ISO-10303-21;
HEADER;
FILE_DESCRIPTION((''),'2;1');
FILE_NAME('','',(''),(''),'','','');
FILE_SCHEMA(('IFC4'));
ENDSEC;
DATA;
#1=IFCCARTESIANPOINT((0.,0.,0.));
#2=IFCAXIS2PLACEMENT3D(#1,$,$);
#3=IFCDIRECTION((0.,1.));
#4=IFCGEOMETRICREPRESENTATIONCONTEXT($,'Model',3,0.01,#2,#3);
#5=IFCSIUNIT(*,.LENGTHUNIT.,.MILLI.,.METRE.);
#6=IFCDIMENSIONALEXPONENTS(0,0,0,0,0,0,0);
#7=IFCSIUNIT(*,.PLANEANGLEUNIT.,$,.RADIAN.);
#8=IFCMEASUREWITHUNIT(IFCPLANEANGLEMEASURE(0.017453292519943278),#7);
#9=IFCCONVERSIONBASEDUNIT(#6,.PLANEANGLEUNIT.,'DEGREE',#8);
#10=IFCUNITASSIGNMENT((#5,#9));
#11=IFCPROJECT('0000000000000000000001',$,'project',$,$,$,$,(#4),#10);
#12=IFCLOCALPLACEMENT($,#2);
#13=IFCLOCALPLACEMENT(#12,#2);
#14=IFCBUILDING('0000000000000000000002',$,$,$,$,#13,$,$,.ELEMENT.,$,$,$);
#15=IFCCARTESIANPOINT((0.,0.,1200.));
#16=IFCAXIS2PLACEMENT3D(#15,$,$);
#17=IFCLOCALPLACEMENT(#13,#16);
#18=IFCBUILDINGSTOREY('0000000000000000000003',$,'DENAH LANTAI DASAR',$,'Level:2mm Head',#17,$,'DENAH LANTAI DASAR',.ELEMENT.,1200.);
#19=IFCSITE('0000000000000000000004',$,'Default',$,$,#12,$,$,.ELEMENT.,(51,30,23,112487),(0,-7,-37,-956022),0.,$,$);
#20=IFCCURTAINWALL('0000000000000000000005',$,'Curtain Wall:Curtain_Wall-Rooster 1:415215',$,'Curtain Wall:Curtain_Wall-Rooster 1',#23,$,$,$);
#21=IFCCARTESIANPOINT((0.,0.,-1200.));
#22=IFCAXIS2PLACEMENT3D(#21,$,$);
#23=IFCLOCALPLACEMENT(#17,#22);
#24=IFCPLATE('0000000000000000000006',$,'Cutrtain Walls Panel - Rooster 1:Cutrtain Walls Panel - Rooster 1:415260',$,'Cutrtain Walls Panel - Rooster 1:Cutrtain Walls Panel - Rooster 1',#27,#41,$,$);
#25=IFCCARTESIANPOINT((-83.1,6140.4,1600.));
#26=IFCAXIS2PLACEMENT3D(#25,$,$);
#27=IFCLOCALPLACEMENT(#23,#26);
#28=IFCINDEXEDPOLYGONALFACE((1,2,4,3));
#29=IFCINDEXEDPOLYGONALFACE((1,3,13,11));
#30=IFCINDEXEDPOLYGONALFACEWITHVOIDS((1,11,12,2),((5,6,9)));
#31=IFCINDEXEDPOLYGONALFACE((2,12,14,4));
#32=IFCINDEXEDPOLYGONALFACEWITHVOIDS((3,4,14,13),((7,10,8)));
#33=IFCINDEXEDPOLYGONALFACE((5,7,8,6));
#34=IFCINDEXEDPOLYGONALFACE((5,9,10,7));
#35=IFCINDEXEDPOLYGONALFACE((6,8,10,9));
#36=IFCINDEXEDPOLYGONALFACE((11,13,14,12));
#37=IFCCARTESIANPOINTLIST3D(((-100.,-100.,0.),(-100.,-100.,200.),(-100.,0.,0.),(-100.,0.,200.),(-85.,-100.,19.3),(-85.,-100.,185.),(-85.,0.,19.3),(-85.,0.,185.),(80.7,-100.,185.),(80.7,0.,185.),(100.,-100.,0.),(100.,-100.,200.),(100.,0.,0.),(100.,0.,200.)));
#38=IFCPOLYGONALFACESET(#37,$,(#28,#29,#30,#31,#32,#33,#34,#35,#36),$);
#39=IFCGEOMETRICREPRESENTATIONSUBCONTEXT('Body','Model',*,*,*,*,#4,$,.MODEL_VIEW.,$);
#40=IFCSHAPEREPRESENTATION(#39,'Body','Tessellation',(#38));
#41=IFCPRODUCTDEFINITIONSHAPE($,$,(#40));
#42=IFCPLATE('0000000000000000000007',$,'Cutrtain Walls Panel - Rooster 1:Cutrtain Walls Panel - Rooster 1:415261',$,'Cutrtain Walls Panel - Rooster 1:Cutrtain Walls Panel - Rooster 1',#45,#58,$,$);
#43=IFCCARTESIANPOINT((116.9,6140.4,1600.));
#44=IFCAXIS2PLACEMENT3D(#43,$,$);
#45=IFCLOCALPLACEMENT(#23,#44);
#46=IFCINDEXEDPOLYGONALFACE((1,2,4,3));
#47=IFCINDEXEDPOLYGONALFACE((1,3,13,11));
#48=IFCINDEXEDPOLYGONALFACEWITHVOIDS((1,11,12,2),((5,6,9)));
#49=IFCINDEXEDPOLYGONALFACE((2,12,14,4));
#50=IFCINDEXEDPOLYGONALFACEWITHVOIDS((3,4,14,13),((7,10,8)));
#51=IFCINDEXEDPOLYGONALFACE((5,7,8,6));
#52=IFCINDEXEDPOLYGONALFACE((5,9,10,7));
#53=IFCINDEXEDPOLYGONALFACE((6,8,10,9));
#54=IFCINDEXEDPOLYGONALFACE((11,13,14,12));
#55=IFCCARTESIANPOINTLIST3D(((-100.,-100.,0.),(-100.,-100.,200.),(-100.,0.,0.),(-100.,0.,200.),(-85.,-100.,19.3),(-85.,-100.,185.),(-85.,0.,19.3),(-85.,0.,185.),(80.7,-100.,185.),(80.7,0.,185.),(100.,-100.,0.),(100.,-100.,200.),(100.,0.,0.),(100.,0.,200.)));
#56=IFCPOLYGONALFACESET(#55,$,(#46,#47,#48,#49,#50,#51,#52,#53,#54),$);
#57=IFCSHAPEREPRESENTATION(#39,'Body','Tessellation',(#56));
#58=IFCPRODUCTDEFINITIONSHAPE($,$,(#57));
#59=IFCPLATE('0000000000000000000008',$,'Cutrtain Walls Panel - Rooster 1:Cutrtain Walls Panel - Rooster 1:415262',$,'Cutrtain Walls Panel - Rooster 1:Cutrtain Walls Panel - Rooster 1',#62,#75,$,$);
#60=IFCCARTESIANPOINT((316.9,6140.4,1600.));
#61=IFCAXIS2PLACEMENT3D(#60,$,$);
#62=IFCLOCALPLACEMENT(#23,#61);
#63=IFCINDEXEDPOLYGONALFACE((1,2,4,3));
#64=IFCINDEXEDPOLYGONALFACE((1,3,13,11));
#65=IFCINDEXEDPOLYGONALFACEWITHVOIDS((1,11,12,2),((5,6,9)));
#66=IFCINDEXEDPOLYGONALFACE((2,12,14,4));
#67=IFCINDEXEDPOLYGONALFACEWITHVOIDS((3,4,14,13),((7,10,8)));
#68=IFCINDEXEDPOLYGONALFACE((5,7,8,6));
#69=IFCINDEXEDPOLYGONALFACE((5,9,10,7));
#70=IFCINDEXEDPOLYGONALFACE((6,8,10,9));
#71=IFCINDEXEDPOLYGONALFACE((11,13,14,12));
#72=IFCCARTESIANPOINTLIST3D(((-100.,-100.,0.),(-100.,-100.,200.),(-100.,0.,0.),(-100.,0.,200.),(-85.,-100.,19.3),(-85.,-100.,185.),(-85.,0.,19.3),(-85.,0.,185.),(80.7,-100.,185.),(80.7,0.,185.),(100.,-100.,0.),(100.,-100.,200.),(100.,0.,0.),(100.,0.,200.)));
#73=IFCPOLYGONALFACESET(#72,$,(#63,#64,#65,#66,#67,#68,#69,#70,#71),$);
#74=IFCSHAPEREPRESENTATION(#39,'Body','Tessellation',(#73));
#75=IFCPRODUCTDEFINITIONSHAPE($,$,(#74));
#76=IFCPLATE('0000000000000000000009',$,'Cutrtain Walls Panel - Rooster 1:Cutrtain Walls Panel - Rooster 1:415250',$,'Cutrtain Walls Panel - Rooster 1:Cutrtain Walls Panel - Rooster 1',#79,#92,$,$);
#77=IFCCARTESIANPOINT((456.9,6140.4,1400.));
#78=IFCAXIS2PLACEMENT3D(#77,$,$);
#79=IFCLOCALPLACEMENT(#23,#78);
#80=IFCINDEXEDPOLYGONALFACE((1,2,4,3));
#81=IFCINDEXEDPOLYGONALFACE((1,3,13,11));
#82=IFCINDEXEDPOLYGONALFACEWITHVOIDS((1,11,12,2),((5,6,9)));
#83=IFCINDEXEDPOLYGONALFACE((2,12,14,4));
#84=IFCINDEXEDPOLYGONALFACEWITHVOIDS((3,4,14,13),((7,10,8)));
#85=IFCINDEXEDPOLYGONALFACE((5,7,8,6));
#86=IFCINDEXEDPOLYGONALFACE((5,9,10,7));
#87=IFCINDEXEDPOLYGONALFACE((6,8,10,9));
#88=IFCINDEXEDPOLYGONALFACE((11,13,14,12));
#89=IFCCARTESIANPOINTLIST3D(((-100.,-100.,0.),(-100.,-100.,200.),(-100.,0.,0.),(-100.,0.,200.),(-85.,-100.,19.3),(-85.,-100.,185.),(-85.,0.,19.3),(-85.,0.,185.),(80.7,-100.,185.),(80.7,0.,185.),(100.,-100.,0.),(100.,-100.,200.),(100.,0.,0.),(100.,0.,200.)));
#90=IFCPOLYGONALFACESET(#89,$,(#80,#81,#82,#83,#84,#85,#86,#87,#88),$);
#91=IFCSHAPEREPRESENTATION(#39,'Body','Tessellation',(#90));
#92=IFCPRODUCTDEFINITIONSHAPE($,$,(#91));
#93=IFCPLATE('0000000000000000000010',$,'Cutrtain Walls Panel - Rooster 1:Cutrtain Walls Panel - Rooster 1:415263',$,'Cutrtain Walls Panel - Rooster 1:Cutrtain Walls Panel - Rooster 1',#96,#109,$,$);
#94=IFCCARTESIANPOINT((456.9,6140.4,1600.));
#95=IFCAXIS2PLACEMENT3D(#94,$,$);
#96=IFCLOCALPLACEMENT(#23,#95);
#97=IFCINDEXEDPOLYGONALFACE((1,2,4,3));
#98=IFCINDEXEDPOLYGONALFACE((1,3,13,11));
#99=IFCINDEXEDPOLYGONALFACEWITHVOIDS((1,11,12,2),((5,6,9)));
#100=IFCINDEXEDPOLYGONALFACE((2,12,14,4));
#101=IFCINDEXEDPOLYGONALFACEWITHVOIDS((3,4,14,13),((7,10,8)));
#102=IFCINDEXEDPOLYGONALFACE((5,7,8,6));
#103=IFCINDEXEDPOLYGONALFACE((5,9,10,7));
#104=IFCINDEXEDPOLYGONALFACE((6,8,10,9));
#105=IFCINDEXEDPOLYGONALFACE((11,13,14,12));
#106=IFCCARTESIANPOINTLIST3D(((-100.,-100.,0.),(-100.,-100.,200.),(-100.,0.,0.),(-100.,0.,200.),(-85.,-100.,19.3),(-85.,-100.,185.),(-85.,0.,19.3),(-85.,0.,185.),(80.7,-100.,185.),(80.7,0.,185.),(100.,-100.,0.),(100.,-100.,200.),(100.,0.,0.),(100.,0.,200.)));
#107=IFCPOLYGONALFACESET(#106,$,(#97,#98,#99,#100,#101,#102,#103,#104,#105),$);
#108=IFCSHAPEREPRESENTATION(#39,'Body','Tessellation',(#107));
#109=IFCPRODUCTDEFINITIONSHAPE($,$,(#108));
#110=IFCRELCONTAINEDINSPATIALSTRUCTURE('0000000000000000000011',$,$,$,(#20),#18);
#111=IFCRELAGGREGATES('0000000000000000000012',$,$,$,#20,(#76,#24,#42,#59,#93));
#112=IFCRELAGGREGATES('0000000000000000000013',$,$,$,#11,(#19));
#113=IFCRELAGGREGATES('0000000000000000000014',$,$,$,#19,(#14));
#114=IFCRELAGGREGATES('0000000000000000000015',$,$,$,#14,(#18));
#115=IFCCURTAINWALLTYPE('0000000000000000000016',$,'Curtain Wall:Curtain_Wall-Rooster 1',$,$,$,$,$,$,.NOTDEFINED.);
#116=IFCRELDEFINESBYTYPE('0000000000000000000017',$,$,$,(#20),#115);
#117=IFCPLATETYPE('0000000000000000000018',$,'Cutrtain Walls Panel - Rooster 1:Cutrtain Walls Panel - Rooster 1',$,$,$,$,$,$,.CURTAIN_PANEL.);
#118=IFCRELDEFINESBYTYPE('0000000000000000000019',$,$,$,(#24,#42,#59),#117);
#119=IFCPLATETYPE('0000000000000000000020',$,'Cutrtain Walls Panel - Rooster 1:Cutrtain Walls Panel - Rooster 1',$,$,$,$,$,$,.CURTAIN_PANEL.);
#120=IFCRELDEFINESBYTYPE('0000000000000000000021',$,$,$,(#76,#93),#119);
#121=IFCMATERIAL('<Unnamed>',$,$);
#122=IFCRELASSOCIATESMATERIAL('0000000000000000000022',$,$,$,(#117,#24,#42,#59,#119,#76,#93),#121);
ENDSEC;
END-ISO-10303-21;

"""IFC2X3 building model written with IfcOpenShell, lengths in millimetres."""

from ifc_helpers import new_model, entity, si_unit, converted_unit, direction, frame, origin, place, context, subcontext, project, spatial, polyline, outline, extrude, source, transform, mapped, material, type_object, type_shapes, element, aggregate, save


model = new_model("IFC2X3")

# Units and contexts
model_context = context("Model", 3, precision=0.01, world=origin(), true_north=direction((0.0, 1.0)))
body_context = subcontext(model_context, "Body", "Model", "MODEL_VIEW")
ifc_project = project(units=[si_unit("LENGTHUNIT", "METRE", prefix="MILLI"), converted_unit("PLANEANGLEUNIT", "DEGREE", entity("IfcPlaneAngleMeasure", 0.017453292519943278), si_unit("PLANEANGLEUNIT", "RADIAN"), dimensions=[0, 0, 0, 0, 0, 0, 0])], contexts=[model_context])

# Site, building, storey
site_placement = place(None, origin())
site = spatial("IfcSite", under=ifc_project, at=site_placement, Name="Default", CompositionType="ELEMENT", RefLatitude=(51, 30, 23, 112487), RefLongitude=(0, -7, -37, -956022), RefElevation=0.0)
building_placement = place(site_placement, origin())
building = spatial("IfcBuilding", under=site, at=building_placement, CompositionType="ELEMENT")
storey_placement = place(building_placement, frame((0.0, 0.0, 1200.0)))
storey = spatial("IfcBuildingStorey", under=building, at=storey_placement, Name="DENAH LANTAI DASAR", ObjectType="Level:2mm Head", LongName="DENAH LANTAI DASAR", CompositionType="ELEMENT", Elevation=1200.0)

# Curtain wall, plates
curtain_wall_type = type_object("IfcCurtainWallType", Name="Curtain Wall:Curtain_Wall-Rooster 1", PredefinedType="NOTDEFINED")
ifc_material_1 = material(Name="<Unnamed>")
curtain_wall_1_placement = place(storey_placement, frame((0.0, 0.0, -1200.0)))
curtain_wall_1 = element("IfcCurtainWall", 1, at=curtain_wall_1_placement, inside=storey, type_object=curtain_wall_type, Name="Curtain Wall:Curtain_Wall-Rooster 1:415215", ObjectType="Curtain Wall:Curtain_Wall-Rooster 1")
plate_type_1 = type_object("IfcPlateType", Name="Cutrtain Walls Panel - Rooster 1:Cutrtain Walls Panel - Rooster 1", PredefinedType="CURTAIN_PANEL", material=ifc_material_1)
shared_shape_1 = source(origin(), body_context, "Body", "SweptSolid", [
    extrude(outline(polyline([(-100.0, -100.0), (100.0, -100.0), (100.0, 100.0), (-100.0, 100.0), (-100.0, -100.0)]), holes=[polyline([(80.7, 85.0), (-85.0, -80.7), (-85.0, 85.0), (80.7, 85.0)])]), frame((0.0, -100.0, 100.0), z_axis=(0.0, 1.0, 0.0), x_axis=(0.0, 0.0, -1.0)), (0.0, 0.0, 1.0), 100.0),
])
type_shapes(plate_type_1, [shared_shape_1])
plate_1_placement = place(curtain_wall_1_placement, frame((-83.1, 6140.4, 1600.0)))
plate_1 = element("IfcPlate", 2, at=plate_1_placement, type_object=plate_type_1, material=ifc_material_1, Name="Cutrtain Walls Panel - Rooster 1:Cutrtain Walls Panel - Rooster 1:415260", ObjectType="Cutrtain Walls Panel - Rooster 1:Cutrtain Walls Panel - Rooster 1", context=body_context, shape_type="MappedRepresentation", body=[
    mapped(shared_shape_1, transform((0.0, 0.0, 0.0), scale=1.0)),
])
plate_2_placement = place(curtain_wall_1_placement, frame((116.9, 6140.4, 1600.0)))
plate_2 = element("IfcPlate", 3, at=plate_2_placement, type_object=plate_type_1, material=ifc_material_1, Name="Cutrtain Walls Panel - Rooster 1:Cutrtain Walls Panel - Rooster 1:415261", ObjectType="Cutrtain Walls Panel - Rooster 1:Cutrtain Walls Panel - Rooster 1", context=body_context, shape_type="MappedRepresentation", body=[
    mapped(shared_shape_1, transform((0.0, 0.0, 0.0), scale=1.0)),
])
plate_3_placement = place(curtain_wall_1_placement, frame((316.9, 6140.4, 1600.0)))
plate_3 = element("IfcPlate", 4, at=plate_3_placement, type_object=plate_type_1, material=ifc_material_1, Name="Cutrtain Walls Panel - Rooster 1:Cutrtain Walls Panel - Rooster 1:415262", ObjectType="Cutrtain Walls Panel - Rooster 1:Cutrtain Walls Panel - Rooster 1", context=body_context, shape_type="MappedRepresentation", body=[
    mapped(shared_shape_1, transform((0.0, 0.0, 0.0), scale=1.0)),
])
plate_type_2 = type_object("IfcPlateType", Name="Cutrtain Walls Panel - Rooster 1:Cutrtain Walls Panel - Rooster 1", PredefinedType="CURTAIN_PANEL", material=ifc_material_1)
shared_shape_2 = source(origin(), body_context, "Body", "SweptSolid", [
    extrude(outline(polyline([(-100.0, -100.0), (100.0, -100.0), (100.0, 100.0), (-100.0, 100.0), (-100.0, -100.0)]), holes=[polyline([(80.7, 85.0), (-85.0, -80.7), (-85.0, 85.0), (80.7, 85.0)])]), frame((0.0, -100.0, 100.0), z_axis=(0.0, 1.0, 0.0), x_axis=(0.0, 0.0, -1.0)), (0.0, 0.0, 1.0), 100.0),
])
type_shapes(plate_type_2, [shared_shape_2])
plate_4_placement = place(curtain_wall_1_placement, frame((456.9, 6140.4, 1400.0)))
plate_4 = element("IfcPlate", 5, at=plate_4_placement, type_object=plate_type_2, material=ifc_material_1, Name="Cutrtain Walls Panel - Rooster 1:Cutrtain Walls Panel - Rooster 1:415250", ObjectType="Cutrtain Walls Panel - Rooster 1:Cutrtain Walls Panel - Rooster 1", context=body_context, shape_type="MappedRepresentation", body=[
    mapped(shared_shape_2, transform((0.0, 0.0, 0.0), scale=1.0)),
])
plate_5_placement = place(curtain_wall_1_placement, frame((456.9, 6140.4, 1600.0)))
plate_5 = element("IfcPlate", 6, at=plate_5_placement, type_object=plate_type_2, material=ifc_material_1, Name="Cutrtain Walls Panel - Rooster 1:Cutrtain Walls Panel - Rooster 1:415263", ObjectType="Cutrtain Walls Panel - Rooster 1:Cutrtain Walls Panel - Rooster 1", context=body_context, shape_type="MappedRepresentation", body=[
    mapped(shared_shape_2, transform((0.0, 0.0, 0.0), scale=1.0)),
])
aggregate(curtain_wall_1, [plate_4, plate_1, plate_2, plate_3, plate_5])

save(model, "model.ifc")
